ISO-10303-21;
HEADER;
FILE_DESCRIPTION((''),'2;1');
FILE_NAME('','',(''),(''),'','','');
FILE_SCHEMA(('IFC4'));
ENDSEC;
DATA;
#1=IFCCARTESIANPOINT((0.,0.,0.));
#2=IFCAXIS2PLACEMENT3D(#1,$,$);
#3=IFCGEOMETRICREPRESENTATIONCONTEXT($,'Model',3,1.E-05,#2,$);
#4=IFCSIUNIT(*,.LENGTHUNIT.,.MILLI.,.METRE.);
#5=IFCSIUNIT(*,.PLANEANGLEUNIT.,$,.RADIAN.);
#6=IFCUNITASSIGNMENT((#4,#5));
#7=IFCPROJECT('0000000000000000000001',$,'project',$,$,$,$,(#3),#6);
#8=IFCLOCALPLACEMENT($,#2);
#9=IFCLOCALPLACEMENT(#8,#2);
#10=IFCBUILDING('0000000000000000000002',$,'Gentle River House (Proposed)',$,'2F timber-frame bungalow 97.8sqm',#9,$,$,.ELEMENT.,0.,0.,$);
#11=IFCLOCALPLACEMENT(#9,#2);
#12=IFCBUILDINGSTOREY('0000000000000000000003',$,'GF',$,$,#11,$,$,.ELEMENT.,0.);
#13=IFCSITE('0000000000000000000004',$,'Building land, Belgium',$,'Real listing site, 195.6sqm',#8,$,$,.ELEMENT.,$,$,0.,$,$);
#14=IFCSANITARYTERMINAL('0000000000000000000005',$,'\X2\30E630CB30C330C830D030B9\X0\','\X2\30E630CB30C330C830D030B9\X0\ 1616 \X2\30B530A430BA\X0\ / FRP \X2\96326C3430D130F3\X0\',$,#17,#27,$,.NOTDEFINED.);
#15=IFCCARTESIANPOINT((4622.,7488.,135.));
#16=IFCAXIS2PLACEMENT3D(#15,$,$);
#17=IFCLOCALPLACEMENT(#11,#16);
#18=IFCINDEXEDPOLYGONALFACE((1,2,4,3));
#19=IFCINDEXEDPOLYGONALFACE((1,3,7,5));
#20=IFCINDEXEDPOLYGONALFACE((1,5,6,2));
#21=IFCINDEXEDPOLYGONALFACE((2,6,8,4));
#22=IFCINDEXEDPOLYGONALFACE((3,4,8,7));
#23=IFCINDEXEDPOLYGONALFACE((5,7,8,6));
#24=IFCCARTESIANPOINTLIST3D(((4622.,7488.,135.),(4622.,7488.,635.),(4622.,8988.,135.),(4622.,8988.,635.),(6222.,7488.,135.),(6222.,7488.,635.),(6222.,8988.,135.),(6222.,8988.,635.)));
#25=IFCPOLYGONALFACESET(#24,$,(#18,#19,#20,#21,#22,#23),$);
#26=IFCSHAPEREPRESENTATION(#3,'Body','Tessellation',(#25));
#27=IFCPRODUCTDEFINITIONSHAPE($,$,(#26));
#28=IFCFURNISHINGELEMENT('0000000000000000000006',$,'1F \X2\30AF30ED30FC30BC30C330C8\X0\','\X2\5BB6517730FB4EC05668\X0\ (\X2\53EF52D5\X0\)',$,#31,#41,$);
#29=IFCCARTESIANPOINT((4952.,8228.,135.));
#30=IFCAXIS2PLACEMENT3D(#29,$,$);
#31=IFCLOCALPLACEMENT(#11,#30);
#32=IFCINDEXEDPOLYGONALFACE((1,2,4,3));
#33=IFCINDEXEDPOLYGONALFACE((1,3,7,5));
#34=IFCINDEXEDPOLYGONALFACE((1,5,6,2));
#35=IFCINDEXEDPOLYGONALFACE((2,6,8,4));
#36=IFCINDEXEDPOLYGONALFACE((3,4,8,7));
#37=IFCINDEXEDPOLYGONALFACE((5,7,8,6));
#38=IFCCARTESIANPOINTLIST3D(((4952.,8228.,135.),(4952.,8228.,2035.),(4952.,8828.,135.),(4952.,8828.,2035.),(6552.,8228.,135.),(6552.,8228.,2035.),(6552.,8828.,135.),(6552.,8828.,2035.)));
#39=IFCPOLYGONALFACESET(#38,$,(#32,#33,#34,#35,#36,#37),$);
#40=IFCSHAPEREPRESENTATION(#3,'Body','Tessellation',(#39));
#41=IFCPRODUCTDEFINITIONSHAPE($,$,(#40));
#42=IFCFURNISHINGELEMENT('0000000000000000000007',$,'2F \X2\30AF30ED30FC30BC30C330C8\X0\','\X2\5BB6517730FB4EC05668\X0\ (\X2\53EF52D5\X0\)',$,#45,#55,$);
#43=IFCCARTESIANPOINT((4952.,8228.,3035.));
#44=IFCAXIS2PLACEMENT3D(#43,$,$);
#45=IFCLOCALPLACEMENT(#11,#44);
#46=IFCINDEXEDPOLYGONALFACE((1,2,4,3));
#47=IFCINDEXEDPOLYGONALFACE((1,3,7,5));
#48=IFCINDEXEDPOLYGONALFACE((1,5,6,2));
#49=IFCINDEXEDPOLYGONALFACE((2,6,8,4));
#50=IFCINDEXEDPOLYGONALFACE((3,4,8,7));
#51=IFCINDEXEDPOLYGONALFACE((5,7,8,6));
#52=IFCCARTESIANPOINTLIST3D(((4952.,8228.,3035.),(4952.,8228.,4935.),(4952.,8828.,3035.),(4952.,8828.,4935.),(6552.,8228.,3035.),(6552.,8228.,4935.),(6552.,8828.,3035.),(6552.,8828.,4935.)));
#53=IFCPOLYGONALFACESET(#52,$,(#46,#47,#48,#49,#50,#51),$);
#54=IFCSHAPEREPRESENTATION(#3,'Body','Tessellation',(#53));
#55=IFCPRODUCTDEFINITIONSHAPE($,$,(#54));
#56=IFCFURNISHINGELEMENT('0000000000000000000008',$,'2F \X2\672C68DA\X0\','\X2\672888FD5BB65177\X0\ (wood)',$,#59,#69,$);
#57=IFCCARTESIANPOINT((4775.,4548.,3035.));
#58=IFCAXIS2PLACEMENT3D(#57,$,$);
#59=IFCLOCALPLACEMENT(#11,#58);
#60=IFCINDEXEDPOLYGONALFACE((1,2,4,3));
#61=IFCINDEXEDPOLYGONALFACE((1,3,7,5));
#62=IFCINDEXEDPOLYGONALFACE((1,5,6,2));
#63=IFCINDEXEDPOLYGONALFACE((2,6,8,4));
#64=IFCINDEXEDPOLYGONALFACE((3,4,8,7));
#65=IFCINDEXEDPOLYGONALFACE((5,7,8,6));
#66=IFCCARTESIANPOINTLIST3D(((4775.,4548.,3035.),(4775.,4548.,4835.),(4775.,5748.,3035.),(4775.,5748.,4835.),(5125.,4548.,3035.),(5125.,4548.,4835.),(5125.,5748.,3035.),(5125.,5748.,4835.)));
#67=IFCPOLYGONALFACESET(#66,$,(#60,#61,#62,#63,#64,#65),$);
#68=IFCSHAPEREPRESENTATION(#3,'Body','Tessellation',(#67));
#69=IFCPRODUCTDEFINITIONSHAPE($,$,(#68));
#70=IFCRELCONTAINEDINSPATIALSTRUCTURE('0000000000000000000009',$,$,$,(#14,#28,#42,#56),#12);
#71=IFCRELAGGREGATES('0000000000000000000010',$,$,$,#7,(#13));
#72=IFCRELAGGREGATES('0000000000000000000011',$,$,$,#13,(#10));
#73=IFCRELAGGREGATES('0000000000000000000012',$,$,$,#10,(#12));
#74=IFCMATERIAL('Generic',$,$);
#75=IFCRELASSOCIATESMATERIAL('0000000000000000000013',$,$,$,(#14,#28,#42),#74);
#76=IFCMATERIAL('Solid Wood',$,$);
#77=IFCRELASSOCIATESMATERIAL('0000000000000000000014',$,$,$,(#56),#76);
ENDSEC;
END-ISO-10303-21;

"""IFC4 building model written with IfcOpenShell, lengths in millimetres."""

from ifc_helpers import new_model, si_unit, frame, frame_2d, origin, place, context, project, spatial, rectangle, extrude, material, element, save


model = new_model("IFC4")

# Units and contexts
model_context = context("Model", 3, precision=1e-05, world=origin())
ifc_project = project(units=[si_unit("LENGTHUNIT", "METRE", prefix="MILLI"), si_unit("PLANEANGLEUNIT", "RADIAN")], contexts=[model_context])

# Site, building, storey
site_placement = place(None, origin())
site = spatial("IfcSite", under=ifc_project, at=site_placement, Name="Building land, Belgium", ObjectType="Real listing site, 195.6sqm", CompositionType="ELEMENT", RefElevation=0.0)
building_placement = place(site_placement, origin())
building = spatial("IfcBuilding", under=site, at=building_placement, Name="Gentle River House (Proposed)", ObjectType="2F timber-frame bungalow 97.8sqm", CompositionType="ELEMENT", ElevationOfRefHeight=0.0, ElevationOfTerrain=0.0)
storey_placement = place(building_placement, origin())
storey = spatial("IfcBuildingStorey", under=building, at=storey_placement, Name="GF", CompositionType="ELEMENT", Elevation=0.0)

# Shared definitions
ifc_material_1 = material(Name="Solid Wood")

# Shared definitions
ifc_material_2 = material(Name="Generic")

# Sanitary terminal
sanitary_terminal_placement = place(storey_placement, frame((4622.0, 7488.0, 135.0)))
element("IfcSanitaryTerminal", 1, at=sanitary_terminal_placement, inside=storey, material=ifc_material_2, Name="ユニットバス", Description="ユニットバス 1616 サイズ / FRP 防水パン", PredefinedType="NOTDEFINED", context=model_context, shape_type="SweptSolid", body=[
    extrude(rectangle(XDim=1600.0, YDim=1500.0, at=frame_2d((800.0, 750.0))), frame((4622.0, 7488.0, 135.0)), (0.0, 0.0, 1.0), 500.0),
])

# Furnishing elements
furnishing_1_placement = place(storey_placement, frame((4952.0, 8228.0, 135.0)))
element("IfcFurnishingElement", 2, at=furnishing_1_placement, inside=storey, material=ifc_material_2, Name="1F クローゼット", Description="家具・什器 (可動)", context=model_context, shape_type="SweptSolid", body=[
    extrude(rectangle(XDim=1600.0, YDim=600.0, at=frame_2d((800.0, 300.0))), frame((4952.0, 8228.0, 135.0)), (0.0, 0.0, 1.0), 1900.0),
])
furnishing_2_placement = place(storey_placement, frame((4952.0, 8228.0, 3035.0)))
element("IfcFurnishingElement", 3, at=furnishing_2_placement, inside=storey, material=ifc_material_2, Name="2F クローゼット", Description="家具・什器 (可動)", context=model_context, shape_type="SweptSolid", body=[
    extrude(rectangle(XDim=1600.0, YDim=600.0, at=frame_2d((800.0, 300.0))), frame((4952.0, 8228.0, 3035.0)), (0.0, 0.0, 1.0), 1900.0),
])
furnishing_3_placement = place(storey_placement, frame((4775.0, 4548.0, 3035.0)))
element("IfcFurnishingElement", 4, at=furnishing_3_placement, inside=storey, material=ifc_material_1, Name="2F 本棚", Description="木製家具 (wood)", context=model_context, shape_type="SweptSolid", body=[
    extrude(rectangle(XDim=350.0, YDim=1200.0, at=frame_2d((175.0, 600.0))), frame((4775.0, 4548.0, 3035.0)), (0.0, 0.0, 1.0), 1800.0),
])

save(model, "model.ifc")
